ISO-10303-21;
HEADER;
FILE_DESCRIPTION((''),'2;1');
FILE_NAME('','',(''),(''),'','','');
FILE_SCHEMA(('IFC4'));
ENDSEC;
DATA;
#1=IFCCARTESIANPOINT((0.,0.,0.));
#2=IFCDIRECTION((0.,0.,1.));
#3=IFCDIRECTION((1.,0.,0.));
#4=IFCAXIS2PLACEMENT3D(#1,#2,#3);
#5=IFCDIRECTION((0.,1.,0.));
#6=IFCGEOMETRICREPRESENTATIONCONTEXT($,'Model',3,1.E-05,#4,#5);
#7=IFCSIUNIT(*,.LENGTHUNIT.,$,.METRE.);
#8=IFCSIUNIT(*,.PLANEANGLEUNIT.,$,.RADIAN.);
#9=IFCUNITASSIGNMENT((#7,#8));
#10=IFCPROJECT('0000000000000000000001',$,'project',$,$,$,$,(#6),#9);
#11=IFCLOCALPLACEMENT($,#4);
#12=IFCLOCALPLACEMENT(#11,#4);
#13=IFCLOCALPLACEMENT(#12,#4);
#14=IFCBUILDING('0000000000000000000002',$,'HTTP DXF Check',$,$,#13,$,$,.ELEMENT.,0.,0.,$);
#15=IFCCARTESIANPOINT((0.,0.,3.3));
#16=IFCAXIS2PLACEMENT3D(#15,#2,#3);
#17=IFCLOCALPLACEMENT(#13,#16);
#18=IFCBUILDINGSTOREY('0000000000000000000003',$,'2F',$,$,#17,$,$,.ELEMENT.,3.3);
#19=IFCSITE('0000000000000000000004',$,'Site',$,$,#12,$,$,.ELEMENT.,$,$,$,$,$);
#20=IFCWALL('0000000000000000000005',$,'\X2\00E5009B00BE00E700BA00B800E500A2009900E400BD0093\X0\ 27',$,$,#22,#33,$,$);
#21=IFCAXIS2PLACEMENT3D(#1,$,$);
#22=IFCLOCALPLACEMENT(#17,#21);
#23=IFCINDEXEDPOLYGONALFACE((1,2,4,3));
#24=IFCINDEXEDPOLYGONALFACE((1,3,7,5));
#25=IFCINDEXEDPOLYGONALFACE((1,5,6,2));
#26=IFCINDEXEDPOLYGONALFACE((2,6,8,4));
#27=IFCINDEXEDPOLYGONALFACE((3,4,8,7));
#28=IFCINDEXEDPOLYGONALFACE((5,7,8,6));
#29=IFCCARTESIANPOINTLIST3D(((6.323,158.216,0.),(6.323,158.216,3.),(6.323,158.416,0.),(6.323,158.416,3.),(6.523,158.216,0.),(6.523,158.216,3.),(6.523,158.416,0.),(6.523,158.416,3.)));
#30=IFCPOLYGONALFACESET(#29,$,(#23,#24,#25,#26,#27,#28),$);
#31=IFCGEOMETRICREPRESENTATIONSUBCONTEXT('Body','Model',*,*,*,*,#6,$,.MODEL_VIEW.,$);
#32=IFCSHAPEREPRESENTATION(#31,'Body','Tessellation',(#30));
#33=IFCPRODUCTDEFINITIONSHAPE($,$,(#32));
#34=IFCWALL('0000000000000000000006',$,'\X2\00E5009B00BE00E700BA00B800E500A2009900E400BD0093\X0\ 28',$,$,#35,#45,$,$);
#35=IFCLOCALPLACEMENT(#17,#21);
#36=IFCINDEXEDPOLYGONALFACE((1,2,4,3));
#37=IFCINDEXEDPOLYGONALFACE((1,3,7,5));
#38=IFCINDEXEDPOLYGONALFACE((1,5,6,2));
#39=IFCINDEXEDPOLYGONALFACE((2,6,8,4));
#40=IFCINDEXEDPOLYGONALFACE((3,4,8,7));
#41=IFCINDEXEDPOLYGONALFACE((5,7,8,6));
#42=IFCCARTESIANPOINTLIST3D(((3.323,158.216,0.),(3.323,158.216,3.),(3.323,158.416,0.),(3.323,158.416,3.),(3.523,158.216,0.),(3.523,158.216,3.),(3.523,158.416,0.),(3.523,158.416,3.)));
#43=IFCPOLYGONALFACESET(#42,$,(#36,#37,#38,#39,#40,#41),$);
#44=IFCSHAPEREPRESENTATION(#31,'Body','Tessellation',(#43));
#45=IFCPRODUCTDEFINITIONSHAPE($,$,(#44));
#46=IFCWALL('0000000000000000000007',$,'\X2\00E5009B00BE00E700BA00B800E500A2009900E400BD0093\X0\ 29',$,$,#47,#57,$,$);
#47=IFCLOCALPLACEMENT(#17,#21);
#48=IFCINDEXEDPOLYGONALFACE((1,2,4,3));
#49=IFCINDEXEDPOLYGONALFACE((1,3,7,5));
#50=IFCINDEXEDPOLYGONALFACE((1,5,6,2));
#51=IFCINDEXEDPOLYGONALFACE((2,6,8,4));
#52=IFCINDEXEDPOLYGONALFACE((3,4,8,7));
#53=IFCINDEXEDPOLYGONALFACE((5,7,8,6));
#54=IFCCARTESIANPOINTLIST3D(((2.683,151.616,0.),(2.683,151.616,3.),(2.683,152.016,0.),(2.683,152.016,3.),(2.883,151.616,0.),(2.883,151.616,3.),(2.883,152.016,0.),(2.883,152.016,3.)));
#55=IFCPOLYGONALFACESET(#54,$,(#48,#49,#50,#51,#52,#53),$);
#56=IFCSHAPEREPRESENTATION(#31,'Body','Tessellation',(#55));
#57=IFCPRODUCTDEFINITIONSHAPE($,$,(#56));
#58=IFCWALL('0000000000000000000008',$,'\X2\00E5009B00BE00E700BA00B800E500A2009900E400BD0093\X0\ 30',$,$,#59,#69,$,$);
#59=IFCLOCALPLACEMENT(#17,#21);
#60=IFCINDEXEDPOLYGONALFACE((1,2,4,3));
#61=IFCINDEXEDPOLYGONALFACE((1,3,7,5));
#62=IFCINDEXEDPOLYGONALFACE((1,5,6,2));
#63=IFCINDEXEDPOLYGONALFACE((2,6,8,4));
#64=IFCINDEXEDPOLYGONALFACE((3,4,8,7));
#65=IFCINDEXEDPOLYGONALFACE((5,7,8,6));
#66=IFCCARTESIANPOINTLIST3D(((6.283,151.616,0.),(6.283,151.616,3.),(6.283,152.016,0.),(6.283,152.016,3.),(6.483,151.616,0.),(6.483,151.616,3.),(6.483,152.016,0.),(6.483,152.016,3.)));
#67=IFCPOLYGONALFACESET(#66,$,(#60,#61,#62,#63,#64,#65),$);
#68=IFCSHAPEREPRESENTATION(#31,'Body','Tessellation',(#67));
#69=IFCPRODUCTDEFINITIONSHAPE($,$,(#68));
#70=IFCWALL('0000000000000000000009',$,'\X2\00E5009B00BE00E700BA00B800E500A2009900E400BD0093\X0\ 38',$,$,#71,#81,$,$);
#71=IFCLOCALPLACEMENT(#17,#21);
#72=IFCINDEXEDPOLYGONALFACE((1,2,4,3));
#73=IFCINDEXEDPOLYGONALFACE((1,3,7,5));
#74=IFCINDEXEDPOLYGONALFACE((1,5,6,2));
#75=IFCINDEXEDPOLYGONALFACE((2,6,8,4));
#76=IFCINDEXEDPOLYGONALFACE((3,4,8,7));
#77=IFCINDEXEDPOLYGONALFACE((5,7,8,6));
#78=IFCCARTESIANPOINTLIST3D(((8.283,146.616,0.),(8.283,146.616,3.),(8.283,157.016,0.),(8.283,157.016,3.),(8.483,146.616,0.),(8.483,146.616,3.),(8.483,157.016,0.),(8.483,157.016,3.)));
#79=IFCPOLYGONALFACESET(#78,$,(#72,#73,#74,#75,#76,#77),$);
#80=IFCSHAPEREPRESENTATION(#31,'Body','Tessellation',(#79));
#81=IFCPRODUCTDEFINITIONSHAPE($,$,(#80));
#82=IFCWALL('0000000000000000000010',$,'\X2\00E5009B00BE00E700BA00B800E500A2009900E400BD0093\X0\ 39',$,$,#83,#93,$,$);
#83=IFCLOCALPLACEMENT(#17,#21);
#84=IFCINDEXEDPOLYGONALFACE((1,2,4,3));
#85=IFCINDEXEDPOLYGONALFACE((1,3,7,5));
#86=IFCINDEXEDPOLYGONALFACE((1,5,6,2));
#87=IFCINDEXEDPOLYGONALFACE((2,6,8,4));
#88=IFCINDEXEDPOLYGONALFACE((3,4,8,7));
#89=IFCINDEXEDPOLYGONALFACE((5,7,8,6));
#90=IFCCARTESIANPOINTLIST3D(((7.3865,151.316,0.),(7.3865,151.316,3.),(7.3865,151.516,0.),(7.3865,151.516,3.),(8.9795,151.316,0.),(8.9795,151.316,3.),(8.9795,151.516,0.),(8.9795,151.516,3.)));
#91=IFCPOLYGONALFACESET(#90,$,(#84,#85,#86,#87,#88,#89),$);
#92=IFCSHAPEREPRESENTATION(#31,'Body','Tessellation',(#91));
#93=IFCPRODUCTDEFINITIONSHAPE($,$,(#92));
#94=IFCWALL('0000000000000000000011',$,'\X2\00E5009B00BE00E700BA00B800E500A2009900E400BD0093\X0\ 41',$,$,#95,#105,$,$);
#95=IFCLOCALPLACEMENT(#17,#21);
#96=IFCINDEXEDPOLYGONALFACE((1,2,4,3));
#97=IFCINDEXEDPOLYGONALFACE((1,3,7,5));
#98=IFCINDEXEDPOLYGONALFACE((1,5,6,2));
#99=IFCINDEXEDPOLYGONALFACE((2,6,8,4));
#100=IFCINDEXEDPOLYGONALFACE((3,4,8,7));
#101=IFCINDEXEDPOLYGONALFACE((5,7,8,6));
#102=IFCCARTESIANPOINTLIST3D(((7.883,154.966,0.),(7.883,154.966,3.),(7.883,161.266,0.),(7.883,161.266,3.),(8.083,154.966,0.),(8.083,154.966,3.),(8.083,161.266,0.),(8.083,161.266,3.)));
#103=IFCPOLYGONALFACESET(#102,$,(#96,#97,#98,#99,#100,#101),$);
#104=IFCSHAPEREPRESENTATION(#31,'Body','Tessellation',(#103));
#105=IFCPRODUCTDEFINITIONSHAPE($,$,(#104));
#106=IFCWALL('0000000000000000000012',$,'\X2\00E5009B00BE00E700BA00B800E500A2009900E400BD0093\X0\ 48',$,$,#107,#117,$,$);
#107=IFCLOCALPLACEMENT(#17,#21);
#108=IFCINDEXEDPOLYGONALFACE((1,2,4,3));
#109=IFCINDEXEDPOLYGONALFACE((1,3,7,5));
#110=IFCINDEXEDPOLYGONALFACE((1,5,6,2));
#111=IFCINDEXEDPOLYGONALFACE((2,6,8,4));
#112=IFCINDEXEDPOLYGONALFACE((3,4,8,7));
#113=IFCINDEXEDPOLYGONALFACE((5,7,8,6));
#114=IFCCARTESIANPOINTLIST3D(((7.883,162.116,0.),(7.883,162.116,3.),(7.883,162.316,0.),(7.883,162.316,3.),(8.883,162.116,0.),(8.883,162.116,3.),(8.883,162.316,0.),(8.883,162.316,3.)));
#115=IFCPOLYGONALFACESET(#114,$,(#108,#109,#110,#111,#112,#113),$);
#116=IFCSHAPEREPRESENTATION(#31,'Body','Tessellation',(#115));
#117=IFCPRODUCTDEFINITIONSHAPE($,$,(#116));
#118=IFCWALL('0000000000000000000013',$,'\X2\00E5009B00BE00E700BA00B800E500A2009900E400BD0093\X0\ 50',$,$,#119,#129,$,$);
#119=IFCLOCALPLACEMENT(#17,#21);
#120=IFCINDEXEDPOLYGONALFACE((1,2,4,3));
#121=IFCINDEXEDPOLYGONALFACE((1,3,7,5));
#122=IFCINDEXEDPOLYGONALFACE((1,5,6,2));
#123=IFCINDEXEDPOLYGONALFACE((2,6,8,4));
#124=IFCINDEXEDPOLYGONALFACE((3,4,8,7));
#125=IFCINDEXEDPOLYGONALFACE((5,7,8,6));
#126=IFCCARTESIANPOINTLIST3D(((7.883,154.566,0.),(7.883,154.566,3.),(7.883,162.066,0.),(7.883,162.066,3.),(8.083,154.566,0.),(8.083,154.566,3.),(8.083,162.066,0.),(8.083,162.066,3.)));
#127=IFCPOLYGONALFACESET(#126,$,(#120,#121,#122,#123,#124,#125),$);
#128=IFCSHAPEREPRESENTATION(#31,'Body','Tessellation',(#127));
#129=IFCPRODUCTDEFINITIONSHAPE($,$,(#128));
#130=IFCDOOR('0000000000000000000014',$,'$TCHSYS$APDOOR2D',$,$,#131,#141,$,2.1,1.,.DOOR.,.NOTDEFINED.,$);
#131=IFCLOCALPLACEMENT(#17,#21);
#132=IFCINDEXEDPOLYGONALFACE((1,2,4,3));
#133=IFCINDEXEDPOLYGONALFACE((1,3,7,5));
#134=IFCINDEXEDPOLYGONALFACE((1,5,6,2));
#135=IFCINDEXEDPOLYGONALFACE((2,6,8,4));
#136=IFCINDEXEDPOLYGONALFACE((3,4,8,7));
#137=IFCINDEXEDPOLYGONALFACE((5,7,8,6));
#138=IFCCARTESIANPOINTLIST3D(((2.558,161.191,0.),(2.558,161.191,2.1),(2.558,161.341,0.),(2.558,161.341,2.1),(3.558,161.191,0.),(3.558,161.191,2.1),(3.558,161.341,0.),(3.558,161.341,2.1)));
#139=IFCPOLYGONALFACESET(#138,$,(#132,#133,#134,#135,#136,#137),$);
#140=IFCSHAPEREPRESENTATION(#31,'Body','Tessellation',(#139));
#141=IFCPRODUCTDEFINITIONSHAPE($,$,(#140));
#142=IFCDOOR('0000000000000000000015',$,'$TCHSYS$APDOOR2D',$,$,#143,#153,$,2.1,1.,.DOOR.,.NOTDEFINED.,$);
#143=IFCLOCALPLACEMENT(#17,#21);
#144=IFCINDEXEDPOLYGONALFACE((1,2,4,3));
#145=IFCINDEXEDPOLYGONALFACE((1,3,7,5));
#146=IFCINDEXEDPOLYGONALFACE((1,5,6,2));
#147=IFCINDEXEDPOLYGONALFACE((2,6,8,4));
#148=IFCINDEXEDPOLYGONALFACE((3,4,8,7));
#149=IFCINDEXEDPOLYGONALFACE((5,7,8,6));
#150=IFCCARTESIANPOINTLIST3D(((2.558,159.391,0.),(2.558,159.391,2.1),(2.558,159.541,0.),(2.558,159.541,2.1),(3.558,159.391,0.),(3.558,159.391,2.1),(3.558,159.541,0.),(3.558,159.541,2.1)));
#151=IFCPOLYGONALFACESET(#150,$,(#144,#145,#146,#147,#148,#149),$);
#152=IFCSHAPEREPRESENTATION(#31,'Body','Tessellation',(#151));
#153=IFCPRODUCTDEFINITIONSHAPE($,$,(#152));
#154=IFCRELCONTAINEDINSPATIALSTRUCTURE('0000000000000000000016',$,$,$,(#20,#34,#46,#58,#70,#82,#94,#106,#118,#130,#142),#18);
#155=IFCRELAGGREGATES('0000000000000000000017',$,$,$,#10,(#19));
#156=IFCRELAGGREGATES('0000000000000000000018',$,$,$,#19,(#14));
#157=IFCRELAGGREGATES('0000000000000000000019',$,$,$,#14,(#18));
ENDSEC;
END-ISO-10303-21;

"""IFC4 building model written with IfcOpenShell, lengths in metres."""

from ifc_helpers import new_model, si_unit, direction, frame, frame_2d, origin_with_axes, place, context, subcontext, project, spatial, rectangle, extrude, element, save


model = new_model("IFC4")

# Units and contexts
model_context = context("Model", 3, precision=1e-05, world=origin_with_axes(), true_north=direction((0.0, 1.0, 0.0)))
body_context = subcontext(model_context, "Body", "Model", "MODEL_VIEW")
ifc_project = project(units=[si_unit("LENGTHUNIT", "METRE"), si_unit("PLANEANGLEUNIT", "RADIAN")], contexts=[model_context])

# Site, building, storey
placement = place(None, origin_with_axes())
site_placement = place(placement, origin_with_axes())
site = spatial("IfcSite", under=ifc_project, at=site_placement, Name="Site", CompositionType="ELEMENT")
building_placement = place(site_placement, origin_with_axes())
building = spatial("IfcBuilding", under=site, at=building_placement, Name="HTTP DXF Check", CompositionType="ELEMENT", ElevationOfRefHeight=0.0, ElevationOfTerrain=0.0)
storey_placement = place(building_placement, frame((0.0, 0.0, 3.3), z_axis=(0.0, 0.0, 1.0), x_axis=(1.0, 0.0, 0.0)))
storey = spatial("IfcBuildingStorey", under=building, at=storey_placement, Name="2F", CompositionType="ELEMENT", Elevation=3.3)

# Walls
for number, where, z_axis, x_axis, name in (
    (1, (6.423, 158.316, 0.0), (0.0, 0.0, 1.0), (0.0, -1.0, 0.0), "å\u009b¾çº¸å¢\u0099ä½\u0093 27"),
    (2, (3.423, 158.316, 0.0), (0.0, 0.0, 1.0), (0.0, -1.0, 0.0), "å\u009b¾çº¸å¢\u0099ä½\u0093 28"),
):
    element("IfcWall", number, at=place(storey_placement, frame(where, z_axis=z_axis, x_axis=x_axis)), inside=storey, Name=name, context=body_context, shape_type="SweptSolid", body=[
        extrude(rectangle(XDim=0.2, YDim=0.2, at=frame_2d((0.0, 0.0), x_axis=(1.0, 0.0, 0.0))), frame((0.0, 0.0, 0.0), z_axis=(0.0, 0.0, 1.0)), (0.0, 0.0, 1.0), 3.0),
    ])
for number, where, z_axis, x_axis, name in (
    (3, (2.783, 151.816, 0.0), (0.0, 0.0, 1.0), (0.0, -1.0, 0.0), "å\u009b¾çº¸å¢\u0099ä½\u0093 29"),
    (4, (6.383, 151.816, 0.0), (0.0, 0.0, 1.0), (0.0, -1.0, 0.0), "å\u009b¾çº¸å¢\u0099ä½\u0093 30"),
):
    element("IfcWall", number, at=place(storey_placement, frame(where, z_axis=z_axis, x_axis=x_axis)), inside=storey, Name=name, context=body_context, shape_type="SweptSolid", body=[
        extrude(rectangle(XDim=0.4, YDim=0.2, at=frame_2d((0.0, 0.0), x_axis=(1.0, 0.0, 0.0))), frame((0.0, 0.0, 0.0), z_axis=(0.0, 0.0, 1.0)), (0.0, 0.0, 1.0), 3.0),
    ])
wall_1_placement = place(storey_placement, frame((8.383, 151.816, 0.0), z_axis=(0.0, 0.0, 1.0), x_axis=(0.0, 1.0, 0.0)))
element("IfcWall", 5, at=wall_1_placement, inside=storey, Name="å\u009b¾çº¸å¢\u0099ä½\u0093 38", context=body_context, shape_type="SweptSolid", body=[
    extrude(rectangle(XDim=10.4, YDim=0.2, at=frame_2d((0.0, 0.0), x_axis=(1.0, 0.0, 0.0))), frame((0.0, 0.0, 0.0), z_axis=(0.0, 0.0, 1.0)), (0.0, 0.0, 1.0), 3.0),
])
wall_2_placement = place(storey_placement, frame((8.183, 151.416, 0.0), z_axis=(0.0, 0.0, 1.0), x_axis=(1.0, 0.0, 0.0)))
element("IfcWall", 6, at=wall_2_placement, inside=storey, Name="å\u009b¾çº¸å¢\u0099ä½\u0093 39", context=body_context, shape_type="SweptSolid", body=[
    extrude(rectangle(XDim=1.593, YDim=0.2, at=frame_2d((0.0, 0.0), x_axis=(1.0, 0.0, 0.0))), frame((0.0, 0.0, 0.0), z_axis=(0.0, 0.0, 1.0)), (0.0, 0.0, 1.0), 3.0),
])
wall_3_placement = place(storey_placement, frame((7.983, 158.116, 0.0), z_axis=(0.0, 0.0, 1.0), x_axis=(0.0, -1.0, 0.0)))
element("IfcWall", 7, at=wall_3_placement, inside=storey, Name="å\u009b¾çº¸å¢\u0099ä½\u0093 41", context=body_context, shape_type="SweptSolid", body=[
    extrude(rectangle(XDim=6.3, YDim=0.2, at=frame_2d((0.0, 0.0), x_axis=(1.0, 0.0, 0.0))), frame((0.0, 0.0, 0.0), z_axis=(0.0, 0.0, 1.0)), (0.0, 0.0, 1.0), 3.0),
])
wall_4_placement = place(storey_placement, frame((8.383, 162.216, 0.0), z_axis=(0.0, 0.0, 1.0), x_axis=(1.0, 0.0, 0.0)))
element("IfcWall", 8, at=wall_4_placement, inside=storey, Name="å\u009b¾çº¸å¢\u0099ä½\u0093 48", context=body_context, shape_type="SweptSolid", body=[
    extrude(rectangle(XDim=1.0, YDim=0.2, at=frame_2d((0.0, 0.0), x_axis=(1.0, 0.0, 0.0))), frame((0.0, 0.0, 0.0), z_axis=(0.0, 0.0, 1.0)), (0.0, 0.0, 1.0), 3.0),
])
wall_5_placement = place(storey_placement, frame((7.983, 158.316, 0.0), z_axis=(0.0, 0.0, 1.0), x_axis=(0.0, 1.0, 0.0)))
element("IfcWall", 9, at=wall_5_placement, inside=storey, Name="å\u009b¾çº¸å¢\u0099ä½\u0093 50", context=body_context, shape_type="SweptSolid", body=[
    extrude(rectangle(XDim=7.5, YDim=0.2, at=frame_2d((0.0, 0.0), x_axis=(1.0, 0.0, 0.0))), frame((0.0, 0.0, 0.0), z_axis=(0.0, 0.0, 1.0)), (0.0, 0.0, 1.0), 3.0),
])

# Doors
for number, where, z_axis, x_axis, name in (
    (10, (3.058, 161.266, 0.0), (0.0, 0.0, 1.0), (1.0, 0.0, 0.0), "$TCHSYS$APDOOR2D"),
    (11, (3.058, 159.466, 0.0), (0.0, 0.0, 1.0), (1.0, 0.0, 0.0), "$TCHSYS$APDOOR2D"),
):
    element("IfcDoor", number, at=place(storey_placement, frame(where, z_axis=z_axis, x_axis=x_axis)), inside=storey, Name=name, OperationType="NOTDEFINED", OverallHeight=2.1, OverallWidth=1.0, PredefinedType="DOOR", context=body_context, shape_type="SweptSolid", body=[
        extrude(rectangle(XDim=1.0, YDim=0.15, at=frame_2d((0.0, 0.0), x_axis=(1.0, 0.0, 0.0))), frame((0.0, 0.0, 0.0), z_axis=(0.0, 0.0, 1.0)), (0.0, 0.0, 1.0), 2.1),
    ])

save(model, "model.ifc")
